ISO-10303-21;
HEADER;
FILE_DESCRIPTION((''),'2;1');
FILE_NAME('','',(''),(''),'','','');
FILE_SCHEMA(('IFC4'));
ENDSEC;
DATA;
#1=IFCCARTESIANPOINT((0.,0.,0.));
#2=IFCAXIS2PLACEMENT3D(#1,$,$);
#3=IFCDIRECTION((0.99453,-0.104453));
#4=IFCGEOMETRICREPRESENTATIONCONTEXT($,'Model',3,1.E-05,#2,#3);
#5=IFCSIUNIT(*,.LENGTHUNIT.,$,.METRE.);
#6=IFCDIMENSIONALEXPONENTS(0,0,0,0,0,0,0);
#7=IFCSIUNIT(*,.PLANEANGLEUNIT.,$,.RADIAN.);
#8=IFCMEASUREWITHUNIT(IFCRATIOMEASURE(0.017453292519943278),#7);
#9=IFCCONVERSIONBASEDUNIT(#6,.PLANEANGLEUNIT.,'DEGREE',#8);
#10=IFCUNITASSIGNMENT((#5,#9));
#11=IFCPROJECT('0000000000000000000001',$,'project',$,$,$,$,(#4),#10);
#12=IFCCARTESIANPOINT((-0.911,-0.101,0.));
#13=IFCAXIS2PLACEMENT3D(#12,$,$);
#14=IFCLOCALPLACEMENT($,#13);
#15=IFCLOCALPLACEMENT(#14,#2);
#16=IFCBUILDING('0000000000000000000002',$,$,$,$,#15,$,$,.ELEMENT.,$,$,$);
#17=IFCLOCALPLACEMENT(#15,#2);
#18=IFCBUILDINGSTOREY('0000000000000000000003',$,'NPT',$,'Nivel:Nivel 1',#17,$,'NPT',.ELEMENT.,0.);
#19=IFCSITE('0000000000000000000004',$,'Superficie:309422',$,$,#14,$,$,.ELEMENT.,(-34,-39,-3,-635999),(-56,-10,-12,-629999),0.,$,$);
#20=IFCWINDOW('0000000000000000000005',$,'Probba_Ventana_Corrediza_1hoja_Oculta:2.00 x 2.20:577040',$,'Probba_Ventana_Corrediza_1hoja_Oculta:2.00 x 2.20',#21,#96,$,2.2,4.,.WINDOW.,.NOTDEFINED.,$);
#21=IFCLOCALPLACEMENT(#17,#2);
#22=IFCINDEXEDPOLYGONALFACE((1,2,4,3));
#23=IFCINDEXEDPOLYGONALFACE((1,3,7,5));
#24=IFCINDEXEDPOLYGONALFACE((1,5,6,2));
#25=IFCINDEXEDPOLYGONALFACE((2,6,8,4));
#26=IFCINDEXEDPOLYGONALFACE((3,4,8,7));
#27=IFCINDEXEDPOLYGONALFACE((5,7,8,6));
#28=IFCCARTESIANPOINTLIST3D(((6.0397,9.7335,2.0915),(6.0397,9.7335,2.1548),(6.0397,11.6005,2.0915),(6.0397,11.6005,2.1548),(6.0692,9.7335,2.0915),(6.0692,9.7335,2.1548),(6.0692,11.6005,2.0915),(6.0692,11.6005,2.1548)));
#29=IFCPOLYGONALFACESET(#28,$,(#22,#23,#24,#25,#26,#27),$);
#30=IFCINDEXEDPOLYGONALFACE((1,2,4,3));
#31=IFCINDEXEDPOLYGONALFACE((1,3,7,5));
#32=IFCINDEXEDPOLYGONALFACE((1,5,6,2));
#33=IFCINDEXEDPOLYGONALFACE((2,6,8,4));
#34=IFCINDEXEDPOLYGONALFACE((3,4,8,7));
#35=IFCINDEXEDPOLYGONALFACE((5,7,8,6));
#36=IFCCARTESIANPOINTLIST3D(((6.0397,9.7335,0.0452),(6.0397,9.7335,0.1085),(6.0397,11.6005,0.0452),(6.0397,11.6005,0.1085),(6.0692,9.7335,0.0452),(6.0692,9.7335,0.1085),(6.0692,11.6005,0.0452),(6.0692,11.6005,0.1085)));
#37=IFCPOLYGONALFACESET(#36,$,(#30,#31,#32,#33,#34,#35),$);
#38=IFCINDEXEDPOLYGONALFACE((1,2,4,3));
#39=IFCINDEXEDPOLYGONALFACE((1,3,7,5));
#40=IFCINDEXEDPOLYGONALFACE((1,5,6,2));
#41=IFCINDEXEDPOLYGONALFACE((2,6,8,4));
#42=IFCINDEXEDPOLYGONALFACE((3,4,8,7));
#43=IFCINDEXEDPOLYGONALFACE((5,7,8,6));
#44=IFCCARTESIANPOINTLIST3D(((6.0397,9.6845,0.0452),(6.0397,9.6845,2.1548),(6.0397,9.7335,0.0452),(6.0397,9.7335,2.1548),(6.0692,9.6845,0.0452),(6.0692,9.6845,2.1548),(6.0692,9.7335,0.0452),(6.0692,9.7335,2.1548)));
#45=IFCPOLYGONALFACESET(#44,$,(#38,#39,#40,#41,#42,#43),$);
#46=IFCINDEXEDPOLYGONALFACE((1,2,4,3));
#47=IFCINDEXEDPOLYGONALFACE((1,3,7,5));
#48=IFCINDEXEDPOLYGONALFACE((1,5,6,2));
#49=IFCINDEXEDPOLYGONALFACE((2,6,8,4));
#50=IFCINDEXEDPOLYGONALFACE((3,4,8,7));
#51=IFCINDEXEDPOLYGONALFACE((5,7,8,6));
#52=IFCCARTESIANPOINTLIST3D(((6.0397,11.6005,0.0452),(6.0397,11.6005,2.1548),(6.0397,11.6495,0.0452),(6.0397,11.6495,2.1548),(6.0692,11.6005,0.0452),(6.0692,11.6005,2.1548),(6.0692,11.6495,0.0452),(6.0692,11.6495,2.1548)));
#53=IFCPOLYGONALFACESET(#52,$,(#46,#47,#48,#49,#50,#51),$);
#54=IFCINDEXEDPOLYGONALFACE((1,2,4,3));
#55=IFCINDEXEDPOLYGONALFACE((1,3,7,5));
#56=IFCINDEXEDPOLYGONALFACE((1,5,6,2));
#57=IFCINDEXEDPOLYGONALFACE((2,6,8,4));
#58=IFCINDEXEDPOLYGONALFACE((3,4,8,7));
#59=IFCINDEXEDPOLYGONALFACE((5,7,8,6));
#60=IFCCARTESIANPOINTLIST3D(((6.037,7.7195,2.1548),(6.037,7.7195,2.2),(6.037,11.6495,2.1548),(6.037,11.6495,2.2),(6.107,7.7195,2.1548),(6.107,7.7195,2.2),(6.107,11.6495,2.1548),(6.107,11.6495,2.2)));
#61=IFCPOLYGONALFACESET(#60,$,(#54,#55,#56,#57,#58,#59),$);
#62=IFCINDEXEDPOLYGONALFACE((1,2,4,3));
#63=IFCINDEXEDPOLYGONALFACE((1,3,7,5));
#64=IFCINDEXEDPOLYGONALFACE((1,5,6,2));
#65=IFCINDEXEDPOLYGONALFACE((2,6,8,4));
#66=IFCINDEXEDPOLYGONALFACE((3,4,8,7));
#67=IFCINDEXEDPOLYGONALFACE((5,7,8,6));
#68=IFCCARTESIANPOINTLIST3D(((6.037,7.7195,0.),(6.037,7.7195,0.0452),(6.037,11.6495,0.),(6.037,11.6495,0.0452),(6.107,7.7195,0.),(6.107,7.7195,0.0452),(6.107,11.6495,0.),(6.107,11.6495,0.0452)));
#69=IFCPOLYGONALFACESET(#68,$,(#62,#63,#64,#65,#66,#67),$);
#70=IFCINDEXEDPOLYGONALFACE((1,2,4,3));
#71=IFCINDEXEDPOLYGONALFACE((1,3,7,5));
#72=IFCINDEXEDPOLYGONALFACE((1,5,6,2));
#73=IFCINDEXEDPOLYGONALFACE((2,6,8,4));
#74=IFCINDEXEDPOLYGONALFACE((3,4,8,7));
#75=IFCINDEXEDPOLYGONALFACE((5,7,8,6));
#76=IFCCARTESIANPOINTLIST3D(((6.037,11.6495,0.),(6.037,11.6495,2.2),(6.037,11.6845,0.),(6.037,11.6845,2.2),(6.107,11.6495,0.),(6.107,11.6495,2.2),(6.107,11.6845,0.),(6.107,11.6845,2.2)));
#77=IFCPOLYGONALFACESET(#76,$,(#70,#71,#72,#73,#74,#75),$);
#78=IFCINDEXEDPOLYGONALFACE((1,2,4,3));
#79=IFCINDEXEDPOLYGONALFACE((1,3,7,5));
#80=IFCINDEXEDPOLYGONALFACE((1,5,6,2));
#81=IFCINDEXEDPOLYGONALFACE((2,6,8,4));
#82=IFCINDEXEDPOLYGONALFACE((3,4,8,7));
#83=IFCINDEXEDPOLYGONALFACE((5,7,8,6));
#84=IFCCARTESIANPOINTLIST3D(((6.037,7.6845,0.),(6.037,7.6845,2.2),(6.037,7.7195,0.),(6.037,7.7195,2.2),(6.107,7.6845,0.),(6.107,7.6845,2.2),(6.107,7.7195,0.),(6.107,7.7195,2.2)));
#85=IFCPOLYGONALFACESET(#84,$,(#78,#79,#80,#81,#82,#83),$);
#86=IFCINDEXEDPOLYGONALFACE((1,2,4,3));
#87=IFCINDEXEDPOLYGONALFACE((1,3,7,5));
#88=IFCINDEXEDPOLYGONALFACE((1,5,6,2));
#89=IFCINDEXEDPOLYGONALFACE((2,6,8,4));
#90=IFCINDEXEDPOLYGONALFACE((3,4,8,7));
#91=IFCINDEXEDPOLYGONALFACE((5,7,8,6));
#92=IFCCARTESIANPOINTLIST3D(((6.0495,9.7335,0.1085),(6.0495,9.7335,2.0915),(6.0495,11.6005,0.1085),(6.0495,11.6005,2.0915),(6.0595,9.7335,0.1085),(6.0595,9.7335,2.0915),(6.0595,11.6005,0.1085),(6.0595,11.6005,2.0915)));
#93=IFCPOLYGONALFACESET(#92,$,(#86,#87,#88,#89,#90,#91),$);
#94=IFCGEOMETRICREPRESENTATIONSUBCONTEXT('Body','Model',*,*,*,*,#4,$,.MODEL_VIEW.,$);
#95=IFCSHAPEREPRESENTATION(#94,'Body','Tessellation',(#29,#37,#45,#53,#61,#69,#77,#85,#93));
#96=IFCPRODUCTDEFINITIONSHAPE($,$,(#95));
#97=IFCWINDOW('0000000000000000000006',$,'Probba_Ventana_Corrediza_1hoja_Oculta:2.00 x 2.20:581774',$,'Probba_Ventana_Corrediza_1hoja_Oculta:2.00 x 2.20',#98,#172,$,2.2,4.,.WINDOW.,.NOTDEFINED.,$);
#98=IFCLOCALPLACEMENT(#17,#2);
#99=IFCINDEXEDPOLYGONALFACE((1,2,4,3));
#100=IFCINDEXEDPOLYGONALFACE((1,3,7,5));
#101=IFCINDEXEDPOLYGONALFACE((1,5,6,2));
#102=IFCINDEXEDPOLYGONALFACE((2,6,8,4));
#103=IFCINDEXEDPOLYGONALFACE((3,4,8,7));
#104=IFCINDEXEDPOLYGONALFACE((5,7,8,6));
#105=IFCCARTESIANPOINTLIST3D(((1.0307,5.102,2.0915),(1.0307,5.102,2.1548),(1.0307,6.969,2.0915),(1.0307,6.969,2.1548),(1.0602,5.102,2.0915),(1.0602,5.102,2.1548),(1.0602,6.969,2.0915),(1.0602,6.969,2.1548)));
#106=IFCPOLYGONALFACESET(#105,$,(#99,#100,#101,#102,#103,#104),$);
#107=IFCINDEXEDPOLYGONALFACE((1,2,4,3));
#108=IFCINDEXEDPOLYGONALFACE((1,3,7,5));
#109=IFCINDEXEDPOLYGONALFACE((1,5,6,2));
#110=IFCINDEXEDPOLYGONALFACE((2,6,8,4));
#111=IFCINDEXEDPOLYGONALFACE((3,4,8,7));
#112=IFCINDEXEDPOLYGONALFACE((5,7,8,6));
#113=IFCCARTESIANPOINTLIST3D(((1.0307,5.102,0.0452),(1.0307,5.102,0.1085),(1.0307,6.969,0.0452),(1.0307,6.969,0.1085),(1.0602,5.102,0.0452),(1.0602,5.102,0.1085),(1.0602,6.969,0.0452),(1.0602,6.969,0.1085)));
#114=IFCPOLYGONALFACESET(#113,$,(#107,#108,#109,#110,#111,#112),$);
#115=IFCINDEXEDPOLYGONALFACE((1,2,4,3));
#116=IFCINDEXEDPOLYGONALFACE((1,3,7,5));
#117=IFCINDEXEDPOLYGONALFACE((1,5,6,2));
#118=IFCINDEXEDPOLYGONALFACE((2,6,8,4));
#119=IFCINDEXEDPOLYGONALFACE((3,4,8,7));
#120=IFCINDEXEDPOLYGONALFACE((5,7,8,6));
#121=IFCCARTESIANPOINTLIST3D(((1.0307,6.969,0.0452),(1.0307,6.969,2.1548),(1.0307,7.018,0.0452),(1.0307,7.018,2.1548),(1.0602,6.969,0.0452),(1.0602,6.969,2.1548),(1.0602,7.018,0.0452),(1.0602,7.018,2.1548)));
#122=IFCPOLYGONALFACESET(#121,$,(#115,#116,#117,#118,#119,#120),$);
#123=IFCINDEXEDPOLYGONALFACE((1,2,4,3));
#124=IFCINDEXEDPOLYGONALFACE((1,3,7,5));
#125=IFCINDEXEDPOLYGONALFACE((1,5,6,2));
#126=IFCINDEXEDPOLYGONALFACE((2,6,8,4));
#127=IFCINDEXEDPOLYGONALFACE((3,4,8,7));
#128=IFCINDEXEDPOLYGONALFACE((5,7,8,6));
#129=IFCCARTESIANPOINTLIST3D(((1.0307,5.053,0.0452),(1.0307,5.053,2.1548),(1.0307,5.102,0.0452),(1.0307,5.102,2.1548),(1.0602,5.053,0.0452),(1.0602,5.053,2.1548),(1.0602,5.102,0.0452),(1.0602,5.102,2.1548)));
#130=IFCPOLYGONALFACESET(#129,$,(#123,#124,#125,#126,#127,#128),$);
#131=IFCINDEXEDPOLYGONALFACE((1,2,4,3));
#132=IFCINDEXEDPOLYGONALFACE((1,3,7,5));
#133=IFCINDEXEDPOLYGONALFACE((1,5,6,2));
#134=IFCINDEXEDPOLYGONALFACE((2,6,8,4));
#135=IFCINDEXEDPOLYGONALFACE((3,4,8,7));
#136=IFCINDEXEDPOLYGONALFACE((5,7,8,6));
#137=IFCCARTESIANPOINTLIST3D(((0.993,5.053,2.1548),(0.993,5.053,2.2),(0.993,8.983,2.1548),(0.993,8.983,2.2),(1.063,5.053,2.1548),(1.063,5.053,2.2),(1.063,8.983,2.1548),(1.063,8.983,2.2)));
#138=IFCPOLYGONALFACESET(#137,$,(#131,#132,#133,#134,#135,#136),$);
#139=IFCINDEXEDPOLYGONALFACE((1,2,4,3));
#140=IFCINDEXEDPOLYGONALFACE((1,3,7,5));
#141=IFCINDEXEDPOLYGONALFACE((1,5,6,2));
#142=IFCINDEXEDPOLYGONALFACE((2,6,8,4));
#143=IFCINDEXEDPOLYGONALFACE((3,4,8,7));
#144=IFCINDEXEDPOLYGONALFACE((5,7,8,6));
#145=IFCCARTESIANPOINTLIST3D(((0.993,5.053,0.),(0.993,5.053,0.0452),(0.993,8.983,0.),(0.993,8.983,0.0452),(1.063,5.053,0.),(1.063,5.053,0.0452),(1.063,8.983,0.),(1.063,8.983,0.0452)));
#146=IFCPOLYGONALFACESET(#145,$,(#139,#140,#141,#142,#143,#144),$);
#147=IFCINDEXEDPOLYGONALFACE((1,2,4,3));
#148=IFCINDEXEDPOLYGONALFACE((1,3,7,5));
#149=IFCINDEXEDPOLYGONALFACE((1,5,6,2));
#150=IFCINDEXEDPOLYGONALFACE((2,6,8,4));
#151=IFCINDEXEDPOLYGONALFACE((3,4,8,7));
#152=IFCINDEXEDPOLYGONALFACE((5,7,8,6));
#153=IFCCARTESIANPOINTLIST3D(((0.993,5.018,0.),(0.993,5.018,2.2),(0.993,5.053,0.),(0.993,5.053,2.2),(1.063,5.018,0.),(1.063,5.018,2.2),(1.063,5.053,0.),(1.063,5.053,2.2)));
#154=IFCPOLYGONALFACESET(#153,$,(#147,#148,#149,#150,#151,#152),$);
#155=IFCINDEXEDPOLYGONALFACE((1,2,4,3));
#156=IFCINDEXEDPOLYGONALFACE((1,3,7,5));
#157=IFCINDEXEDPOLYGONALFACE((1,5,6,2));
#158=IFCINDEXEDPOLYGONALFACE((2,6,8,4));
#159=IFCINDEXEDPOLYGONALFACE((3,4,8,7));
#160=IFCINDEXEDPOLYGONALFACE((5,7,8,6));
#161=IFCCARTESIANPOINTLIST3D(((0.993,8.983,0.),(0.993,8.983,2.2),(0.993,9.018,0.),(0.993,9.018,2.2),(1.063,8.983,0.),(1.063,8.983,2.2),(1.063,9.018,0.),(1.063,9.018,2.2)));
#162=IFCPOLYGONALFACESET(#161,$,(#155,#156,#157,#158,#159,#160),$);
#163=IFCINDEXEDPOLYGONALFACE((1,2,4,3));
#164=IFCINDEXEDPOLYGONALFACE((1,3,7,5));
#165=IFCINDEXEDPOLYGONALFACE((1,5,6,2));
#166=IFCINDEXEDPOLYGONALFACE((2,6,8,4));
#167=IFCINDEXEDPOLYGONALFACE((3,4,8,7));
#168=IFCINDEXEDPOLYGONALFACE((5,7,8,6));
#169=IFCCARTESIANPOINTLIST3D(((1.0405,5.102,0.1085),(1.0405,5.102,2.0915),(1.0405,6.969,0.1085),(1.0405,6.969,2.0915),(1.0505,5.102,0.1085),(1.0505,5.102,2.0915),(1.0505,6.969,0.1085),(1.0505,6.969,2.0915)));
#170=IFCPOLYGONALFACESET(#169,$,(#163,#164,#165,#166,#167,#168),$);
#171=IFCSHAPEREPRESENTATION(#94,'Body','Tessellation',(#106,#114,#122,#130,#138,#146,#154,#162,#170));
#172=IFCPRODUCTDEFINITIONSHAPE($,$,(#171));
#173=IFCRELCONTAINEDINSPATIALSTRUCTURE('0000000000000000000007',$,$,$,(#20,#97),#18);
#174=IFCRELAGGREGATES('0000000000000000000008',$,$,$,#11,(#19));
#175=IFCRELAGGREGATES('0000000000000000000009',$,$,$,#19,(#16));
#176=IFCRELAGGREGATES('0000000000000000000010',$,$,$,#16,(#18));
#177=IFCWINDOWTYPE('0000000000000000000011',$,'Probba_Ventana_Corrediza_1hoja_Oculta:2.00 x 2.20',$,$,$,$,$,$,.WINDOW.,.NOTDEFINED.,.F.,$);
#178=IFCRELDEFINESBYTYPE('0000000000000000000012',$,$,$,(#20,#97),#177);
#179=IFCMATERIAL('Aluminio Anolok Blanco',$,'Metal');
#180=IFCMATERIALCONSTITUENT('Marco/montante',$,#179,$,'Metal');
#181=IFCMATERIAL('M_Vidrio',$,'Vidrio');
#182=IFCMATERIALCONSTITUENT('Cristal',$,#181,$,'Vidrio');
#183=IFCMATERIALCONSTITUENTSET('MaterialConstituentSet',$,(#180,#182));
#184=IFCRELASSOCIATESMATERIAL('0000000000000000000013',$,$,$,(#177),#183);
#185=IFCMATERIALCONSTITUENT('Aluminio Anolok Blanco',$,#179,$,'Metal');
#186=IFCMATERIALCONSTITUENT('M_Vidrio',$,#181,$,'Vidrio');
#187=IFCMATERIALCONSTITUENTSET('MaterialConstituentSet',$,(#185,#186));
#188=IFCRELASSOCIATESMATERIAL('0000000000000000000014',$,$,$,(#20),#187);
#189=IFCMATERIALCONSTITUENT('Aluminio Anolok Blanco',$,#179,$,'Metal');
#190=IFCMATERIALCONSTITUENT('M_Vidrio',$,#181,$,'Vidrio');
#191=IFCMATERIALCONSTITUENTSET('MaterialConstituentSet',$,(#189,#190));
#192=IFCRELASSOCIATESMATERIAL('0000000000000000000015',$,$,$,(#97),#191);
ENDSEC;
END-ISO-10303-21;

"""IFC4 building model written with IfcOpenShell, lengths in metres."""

from ifc_helpers import new_model, entity, si_unit, converted_unit, direction, frame, frame_2d, origin, origin_2d_with_axis, place, context, subcontext, project, spatial, rectangle, extrude, source, transform, mapped, material, constituent, constituent_set, type_object, type_shapes, element, save


model = new_model("IFC4")

# Units and contexts
model_context = context("Model", 3, precision=1e-05, world=origin(), true_north=direction((0.99453, -0.104453)))
body_context = subcontext(model_context, "Body", "Model", "MODEL_VIEW")
ifc_project = project(units=[si_unit("LENGTHUNIT", "METRE"), converted_unit("PLANEANGLEUNIT", "DEGREE", entity("IfcRatioMeasure", 0.017453292519943278), si_unit("PLANEANGLEUNIT", "RADIAN"), dimensions=[0, 0, 0, 0, 0, 0, 0])], contexts=[model_context])

# Site, building, storey
site_placement = place(None, frame((-0.911, -0.101, 0.0)))
site = spatial("IfcSite", under=ifc_project, at=site_placement, Name="Superficie:309422", CompositionType="ELEMENT", RefLatitude=(-34, -39, -3, -635999), RefLongitude=(-56, -10, -12, -629999), RefElevation=0.0)
building_placement = place(site_placement, origin())
building = spatial("IfcBuilding", under=site, at=building_placement, CompositionType="ELEMENT")
storey_placement = place(building_placement, origin())
storey = spatial("IfcBuildingStorey", under=building, at=storey_placement, Name="NPT", ObjectType="Nivel:Nivel 1", LongName="NPT", CompositionType="ELEMENT", Elevation=0.0)

# Windows
ifc_material_1 = material(Name="Aluminio Anolok Blanco", Category="Metal")
ifc_material_2 = material(Name="M_Vidrio", Category="Vidrio")
ifc_constituent_1 = constituent(ifc_material_1, Name="Aluminio Anolok Blanco", Category="Metal")
ifc_constituent_2 = constituent(ifc_material_2, Name="M_Vidrio", Category="Vidrio")
ifc_constituent_set_1 = constituent_set(constituents=[ifc_constituent_1, ifc_constituent_2], Name="MaterialConstituentSet")
ifc_constituent_3 = constituent(ifc_material_1, Name="Marco/montante", Category="Metal")
ifc_constituent_4 = constituent(ifc_material_2, Name="Cristal", Category="Vidrio")
ifc_constituent_set_2 = constituent_set(constituents=[ifc_constituent_3, ifc_constituent_4], Name="MaterialConstituentSet")
window_type_1 = type_object("IfcWindowType", Name="Probba_Ventana_Corrediza_1hoja_Oculta:2.00 x 2.20", ParameterTakesPrecedence=False, PartitioningType="NOTDEFINED", PredefinedType="WINDOW", material=ifc_constituent_set_2)
shared_shape_1 = source(origin(), body_context, "Body", "SweptSolid", [
    extrude(rectangle(XDim=1.867, YDim=0.0295, at=origin_2d_with_axis()), frame((1.0175, -0.0525, 2.0915)), (0.0, 0.0, 1.0), 0.0633),
    extrude(rectangle(XDim=1.867, YDim=0.0295, at=origin_2d_with_axis()), frame((1.0175, -0.0525, 0.0452)), (0.0, 0.0, 1.0), 0.0633),
    extrude(rectangle(XDim=0.0295, YDim=0.049, at=origin_2d_with_axis()), frame((1.9755, -0.0525, 0.0452), z_axis=(0.0, 0.0, 1.0), x_axis=(0.0, 1.0, 0.0)), (0.0, 0.0, 1.0), 2.1096),
    extrude(rectangle(XDim=0.0295, YDim=0.049, at=origin_2d_with_axis()), frame((0.0595, -0.0525, 0.0452), z_axis=(0.0, 0.0, 1.0), x_axis=(0.0, 1.0, 0.0)), (0.0, 0.0, 1.0), 2.1096),
    extrude(rectangle(XDim=3.93, YDim=0.07, at=frame_2d((0.0, 0.0), x_axis=(1.0, 0.0))), frame((2.0, -0.035, 2.1548)), (0.0, 0.0, 1.0), 0.0452),
    extrude(rectangle(XDim=3.93, YDim=0.07, at=frame_2d((0.0, 0.0), x_axis=(1.0, 0.0))), frame((2.0, -0.035, 0.0)), (0.0, 0.0, 1.0), 0.0452),
    extrude(rectangle(XDim=0.035, YDim=0.07, at=origin_2d_with_axis()), frame((0.0175, -0.035, 0.0), z_axis=(0.0, 0.0, 1.0), x_axis=(-1.0, 0.0, 0.0)), (0.0, 0.0, 1.0), 2.2),
    extrude(rectangle(XDim=0.07, YDim=0.035, at=origin_2d_with_axis()), frame((3.9825, -0.035, 0.0), z_axis=(0.0, 0.0, 1.0), x_axis=(0.0, 1.0, 0.0)), (0.0, 0.0, 1.0), 2.2),
    extrude(rectangle(XDim=0.01, YDim=1.867, at=origin_2d_with_axis()), frame((1.0175, -0.0525, 0.1085), z_axis=(0.0, 0.0, 1.0), x_axis=(0.0, 1.0, 0.0)), (0.0, 0.0, 1.0), 1.983),
])
type_shapes(window_type_1, [shared_shape_1])
window_1_placement = place(storey_placement, frame((6.107, 11.6845, 0.0), z_axis=(0.0, 0.0, 1.0), x_axis=(0.0, -1.0, 0.0)))
element("IfcWindow", 1, at=window_1_placement, inside=storey, type_object=window_type_1, material=ifc_constituent_set_1, Name="Probba_Ventana_Corrediza_1hoja_Oculta:2.00 x 2.20:577040", ObjectType="Probba_Ventana_Corrediza_1hoja_Oculta:2.00 x 2.20", OverallHeight=2.2, OverallWidth=4.0, PartitioningType="NOTDEFINED", PredefinedType="WINDOW", context=body_context, shape_type="MappedRepresentation", body=[
    mapped(shared_shape_1, transform((0.0, 0.0, 0.0), scale=1.0)),
])
ifc_constituent_5 = constituent(ifc_material_1, Name="Aluminio Anolok Blanco", Category="Metal")
ifc_constituent_6 = constituent(ifc_material_2, Name="M_Vidrio", Category="Vidrio")
ifc_constituent_set_3 = constituent_set(constituents=[ifc_constituent_5, ifc_constituent_6], Name="MaterialConstituentSet")
window_2_placement = place(storey_placement, frame((0.993, 5.018, 0.0), z_axis=(0.0, 0.0, 1.0), x_axis=(0.0, 1.0, 0.0)))
element("IfcWindow", 2, at=window_2_placement, inside=storey, type_object=window_type_1, material=ifc_constituent_set_3, Name="Probba_Ventana_Corrediza_1hoja_Oculta:2.00 x 2.20:581774", ObjectType="Probba_Ventana_Corrediza_1hoja_Oculta:2.00 x 2.20", OverallHeight=2.2, OverallWidth=4.0, PartitioningType="NOTDEFINED", PredefinedType="WINDOW", context=body_context, shape_type="MappedRepresentation", body=[
    mapped(shared_shape_1, transform((0.0, 0.0, 0.0), scale=1.0)),
])

save(model, "model.ifc")
